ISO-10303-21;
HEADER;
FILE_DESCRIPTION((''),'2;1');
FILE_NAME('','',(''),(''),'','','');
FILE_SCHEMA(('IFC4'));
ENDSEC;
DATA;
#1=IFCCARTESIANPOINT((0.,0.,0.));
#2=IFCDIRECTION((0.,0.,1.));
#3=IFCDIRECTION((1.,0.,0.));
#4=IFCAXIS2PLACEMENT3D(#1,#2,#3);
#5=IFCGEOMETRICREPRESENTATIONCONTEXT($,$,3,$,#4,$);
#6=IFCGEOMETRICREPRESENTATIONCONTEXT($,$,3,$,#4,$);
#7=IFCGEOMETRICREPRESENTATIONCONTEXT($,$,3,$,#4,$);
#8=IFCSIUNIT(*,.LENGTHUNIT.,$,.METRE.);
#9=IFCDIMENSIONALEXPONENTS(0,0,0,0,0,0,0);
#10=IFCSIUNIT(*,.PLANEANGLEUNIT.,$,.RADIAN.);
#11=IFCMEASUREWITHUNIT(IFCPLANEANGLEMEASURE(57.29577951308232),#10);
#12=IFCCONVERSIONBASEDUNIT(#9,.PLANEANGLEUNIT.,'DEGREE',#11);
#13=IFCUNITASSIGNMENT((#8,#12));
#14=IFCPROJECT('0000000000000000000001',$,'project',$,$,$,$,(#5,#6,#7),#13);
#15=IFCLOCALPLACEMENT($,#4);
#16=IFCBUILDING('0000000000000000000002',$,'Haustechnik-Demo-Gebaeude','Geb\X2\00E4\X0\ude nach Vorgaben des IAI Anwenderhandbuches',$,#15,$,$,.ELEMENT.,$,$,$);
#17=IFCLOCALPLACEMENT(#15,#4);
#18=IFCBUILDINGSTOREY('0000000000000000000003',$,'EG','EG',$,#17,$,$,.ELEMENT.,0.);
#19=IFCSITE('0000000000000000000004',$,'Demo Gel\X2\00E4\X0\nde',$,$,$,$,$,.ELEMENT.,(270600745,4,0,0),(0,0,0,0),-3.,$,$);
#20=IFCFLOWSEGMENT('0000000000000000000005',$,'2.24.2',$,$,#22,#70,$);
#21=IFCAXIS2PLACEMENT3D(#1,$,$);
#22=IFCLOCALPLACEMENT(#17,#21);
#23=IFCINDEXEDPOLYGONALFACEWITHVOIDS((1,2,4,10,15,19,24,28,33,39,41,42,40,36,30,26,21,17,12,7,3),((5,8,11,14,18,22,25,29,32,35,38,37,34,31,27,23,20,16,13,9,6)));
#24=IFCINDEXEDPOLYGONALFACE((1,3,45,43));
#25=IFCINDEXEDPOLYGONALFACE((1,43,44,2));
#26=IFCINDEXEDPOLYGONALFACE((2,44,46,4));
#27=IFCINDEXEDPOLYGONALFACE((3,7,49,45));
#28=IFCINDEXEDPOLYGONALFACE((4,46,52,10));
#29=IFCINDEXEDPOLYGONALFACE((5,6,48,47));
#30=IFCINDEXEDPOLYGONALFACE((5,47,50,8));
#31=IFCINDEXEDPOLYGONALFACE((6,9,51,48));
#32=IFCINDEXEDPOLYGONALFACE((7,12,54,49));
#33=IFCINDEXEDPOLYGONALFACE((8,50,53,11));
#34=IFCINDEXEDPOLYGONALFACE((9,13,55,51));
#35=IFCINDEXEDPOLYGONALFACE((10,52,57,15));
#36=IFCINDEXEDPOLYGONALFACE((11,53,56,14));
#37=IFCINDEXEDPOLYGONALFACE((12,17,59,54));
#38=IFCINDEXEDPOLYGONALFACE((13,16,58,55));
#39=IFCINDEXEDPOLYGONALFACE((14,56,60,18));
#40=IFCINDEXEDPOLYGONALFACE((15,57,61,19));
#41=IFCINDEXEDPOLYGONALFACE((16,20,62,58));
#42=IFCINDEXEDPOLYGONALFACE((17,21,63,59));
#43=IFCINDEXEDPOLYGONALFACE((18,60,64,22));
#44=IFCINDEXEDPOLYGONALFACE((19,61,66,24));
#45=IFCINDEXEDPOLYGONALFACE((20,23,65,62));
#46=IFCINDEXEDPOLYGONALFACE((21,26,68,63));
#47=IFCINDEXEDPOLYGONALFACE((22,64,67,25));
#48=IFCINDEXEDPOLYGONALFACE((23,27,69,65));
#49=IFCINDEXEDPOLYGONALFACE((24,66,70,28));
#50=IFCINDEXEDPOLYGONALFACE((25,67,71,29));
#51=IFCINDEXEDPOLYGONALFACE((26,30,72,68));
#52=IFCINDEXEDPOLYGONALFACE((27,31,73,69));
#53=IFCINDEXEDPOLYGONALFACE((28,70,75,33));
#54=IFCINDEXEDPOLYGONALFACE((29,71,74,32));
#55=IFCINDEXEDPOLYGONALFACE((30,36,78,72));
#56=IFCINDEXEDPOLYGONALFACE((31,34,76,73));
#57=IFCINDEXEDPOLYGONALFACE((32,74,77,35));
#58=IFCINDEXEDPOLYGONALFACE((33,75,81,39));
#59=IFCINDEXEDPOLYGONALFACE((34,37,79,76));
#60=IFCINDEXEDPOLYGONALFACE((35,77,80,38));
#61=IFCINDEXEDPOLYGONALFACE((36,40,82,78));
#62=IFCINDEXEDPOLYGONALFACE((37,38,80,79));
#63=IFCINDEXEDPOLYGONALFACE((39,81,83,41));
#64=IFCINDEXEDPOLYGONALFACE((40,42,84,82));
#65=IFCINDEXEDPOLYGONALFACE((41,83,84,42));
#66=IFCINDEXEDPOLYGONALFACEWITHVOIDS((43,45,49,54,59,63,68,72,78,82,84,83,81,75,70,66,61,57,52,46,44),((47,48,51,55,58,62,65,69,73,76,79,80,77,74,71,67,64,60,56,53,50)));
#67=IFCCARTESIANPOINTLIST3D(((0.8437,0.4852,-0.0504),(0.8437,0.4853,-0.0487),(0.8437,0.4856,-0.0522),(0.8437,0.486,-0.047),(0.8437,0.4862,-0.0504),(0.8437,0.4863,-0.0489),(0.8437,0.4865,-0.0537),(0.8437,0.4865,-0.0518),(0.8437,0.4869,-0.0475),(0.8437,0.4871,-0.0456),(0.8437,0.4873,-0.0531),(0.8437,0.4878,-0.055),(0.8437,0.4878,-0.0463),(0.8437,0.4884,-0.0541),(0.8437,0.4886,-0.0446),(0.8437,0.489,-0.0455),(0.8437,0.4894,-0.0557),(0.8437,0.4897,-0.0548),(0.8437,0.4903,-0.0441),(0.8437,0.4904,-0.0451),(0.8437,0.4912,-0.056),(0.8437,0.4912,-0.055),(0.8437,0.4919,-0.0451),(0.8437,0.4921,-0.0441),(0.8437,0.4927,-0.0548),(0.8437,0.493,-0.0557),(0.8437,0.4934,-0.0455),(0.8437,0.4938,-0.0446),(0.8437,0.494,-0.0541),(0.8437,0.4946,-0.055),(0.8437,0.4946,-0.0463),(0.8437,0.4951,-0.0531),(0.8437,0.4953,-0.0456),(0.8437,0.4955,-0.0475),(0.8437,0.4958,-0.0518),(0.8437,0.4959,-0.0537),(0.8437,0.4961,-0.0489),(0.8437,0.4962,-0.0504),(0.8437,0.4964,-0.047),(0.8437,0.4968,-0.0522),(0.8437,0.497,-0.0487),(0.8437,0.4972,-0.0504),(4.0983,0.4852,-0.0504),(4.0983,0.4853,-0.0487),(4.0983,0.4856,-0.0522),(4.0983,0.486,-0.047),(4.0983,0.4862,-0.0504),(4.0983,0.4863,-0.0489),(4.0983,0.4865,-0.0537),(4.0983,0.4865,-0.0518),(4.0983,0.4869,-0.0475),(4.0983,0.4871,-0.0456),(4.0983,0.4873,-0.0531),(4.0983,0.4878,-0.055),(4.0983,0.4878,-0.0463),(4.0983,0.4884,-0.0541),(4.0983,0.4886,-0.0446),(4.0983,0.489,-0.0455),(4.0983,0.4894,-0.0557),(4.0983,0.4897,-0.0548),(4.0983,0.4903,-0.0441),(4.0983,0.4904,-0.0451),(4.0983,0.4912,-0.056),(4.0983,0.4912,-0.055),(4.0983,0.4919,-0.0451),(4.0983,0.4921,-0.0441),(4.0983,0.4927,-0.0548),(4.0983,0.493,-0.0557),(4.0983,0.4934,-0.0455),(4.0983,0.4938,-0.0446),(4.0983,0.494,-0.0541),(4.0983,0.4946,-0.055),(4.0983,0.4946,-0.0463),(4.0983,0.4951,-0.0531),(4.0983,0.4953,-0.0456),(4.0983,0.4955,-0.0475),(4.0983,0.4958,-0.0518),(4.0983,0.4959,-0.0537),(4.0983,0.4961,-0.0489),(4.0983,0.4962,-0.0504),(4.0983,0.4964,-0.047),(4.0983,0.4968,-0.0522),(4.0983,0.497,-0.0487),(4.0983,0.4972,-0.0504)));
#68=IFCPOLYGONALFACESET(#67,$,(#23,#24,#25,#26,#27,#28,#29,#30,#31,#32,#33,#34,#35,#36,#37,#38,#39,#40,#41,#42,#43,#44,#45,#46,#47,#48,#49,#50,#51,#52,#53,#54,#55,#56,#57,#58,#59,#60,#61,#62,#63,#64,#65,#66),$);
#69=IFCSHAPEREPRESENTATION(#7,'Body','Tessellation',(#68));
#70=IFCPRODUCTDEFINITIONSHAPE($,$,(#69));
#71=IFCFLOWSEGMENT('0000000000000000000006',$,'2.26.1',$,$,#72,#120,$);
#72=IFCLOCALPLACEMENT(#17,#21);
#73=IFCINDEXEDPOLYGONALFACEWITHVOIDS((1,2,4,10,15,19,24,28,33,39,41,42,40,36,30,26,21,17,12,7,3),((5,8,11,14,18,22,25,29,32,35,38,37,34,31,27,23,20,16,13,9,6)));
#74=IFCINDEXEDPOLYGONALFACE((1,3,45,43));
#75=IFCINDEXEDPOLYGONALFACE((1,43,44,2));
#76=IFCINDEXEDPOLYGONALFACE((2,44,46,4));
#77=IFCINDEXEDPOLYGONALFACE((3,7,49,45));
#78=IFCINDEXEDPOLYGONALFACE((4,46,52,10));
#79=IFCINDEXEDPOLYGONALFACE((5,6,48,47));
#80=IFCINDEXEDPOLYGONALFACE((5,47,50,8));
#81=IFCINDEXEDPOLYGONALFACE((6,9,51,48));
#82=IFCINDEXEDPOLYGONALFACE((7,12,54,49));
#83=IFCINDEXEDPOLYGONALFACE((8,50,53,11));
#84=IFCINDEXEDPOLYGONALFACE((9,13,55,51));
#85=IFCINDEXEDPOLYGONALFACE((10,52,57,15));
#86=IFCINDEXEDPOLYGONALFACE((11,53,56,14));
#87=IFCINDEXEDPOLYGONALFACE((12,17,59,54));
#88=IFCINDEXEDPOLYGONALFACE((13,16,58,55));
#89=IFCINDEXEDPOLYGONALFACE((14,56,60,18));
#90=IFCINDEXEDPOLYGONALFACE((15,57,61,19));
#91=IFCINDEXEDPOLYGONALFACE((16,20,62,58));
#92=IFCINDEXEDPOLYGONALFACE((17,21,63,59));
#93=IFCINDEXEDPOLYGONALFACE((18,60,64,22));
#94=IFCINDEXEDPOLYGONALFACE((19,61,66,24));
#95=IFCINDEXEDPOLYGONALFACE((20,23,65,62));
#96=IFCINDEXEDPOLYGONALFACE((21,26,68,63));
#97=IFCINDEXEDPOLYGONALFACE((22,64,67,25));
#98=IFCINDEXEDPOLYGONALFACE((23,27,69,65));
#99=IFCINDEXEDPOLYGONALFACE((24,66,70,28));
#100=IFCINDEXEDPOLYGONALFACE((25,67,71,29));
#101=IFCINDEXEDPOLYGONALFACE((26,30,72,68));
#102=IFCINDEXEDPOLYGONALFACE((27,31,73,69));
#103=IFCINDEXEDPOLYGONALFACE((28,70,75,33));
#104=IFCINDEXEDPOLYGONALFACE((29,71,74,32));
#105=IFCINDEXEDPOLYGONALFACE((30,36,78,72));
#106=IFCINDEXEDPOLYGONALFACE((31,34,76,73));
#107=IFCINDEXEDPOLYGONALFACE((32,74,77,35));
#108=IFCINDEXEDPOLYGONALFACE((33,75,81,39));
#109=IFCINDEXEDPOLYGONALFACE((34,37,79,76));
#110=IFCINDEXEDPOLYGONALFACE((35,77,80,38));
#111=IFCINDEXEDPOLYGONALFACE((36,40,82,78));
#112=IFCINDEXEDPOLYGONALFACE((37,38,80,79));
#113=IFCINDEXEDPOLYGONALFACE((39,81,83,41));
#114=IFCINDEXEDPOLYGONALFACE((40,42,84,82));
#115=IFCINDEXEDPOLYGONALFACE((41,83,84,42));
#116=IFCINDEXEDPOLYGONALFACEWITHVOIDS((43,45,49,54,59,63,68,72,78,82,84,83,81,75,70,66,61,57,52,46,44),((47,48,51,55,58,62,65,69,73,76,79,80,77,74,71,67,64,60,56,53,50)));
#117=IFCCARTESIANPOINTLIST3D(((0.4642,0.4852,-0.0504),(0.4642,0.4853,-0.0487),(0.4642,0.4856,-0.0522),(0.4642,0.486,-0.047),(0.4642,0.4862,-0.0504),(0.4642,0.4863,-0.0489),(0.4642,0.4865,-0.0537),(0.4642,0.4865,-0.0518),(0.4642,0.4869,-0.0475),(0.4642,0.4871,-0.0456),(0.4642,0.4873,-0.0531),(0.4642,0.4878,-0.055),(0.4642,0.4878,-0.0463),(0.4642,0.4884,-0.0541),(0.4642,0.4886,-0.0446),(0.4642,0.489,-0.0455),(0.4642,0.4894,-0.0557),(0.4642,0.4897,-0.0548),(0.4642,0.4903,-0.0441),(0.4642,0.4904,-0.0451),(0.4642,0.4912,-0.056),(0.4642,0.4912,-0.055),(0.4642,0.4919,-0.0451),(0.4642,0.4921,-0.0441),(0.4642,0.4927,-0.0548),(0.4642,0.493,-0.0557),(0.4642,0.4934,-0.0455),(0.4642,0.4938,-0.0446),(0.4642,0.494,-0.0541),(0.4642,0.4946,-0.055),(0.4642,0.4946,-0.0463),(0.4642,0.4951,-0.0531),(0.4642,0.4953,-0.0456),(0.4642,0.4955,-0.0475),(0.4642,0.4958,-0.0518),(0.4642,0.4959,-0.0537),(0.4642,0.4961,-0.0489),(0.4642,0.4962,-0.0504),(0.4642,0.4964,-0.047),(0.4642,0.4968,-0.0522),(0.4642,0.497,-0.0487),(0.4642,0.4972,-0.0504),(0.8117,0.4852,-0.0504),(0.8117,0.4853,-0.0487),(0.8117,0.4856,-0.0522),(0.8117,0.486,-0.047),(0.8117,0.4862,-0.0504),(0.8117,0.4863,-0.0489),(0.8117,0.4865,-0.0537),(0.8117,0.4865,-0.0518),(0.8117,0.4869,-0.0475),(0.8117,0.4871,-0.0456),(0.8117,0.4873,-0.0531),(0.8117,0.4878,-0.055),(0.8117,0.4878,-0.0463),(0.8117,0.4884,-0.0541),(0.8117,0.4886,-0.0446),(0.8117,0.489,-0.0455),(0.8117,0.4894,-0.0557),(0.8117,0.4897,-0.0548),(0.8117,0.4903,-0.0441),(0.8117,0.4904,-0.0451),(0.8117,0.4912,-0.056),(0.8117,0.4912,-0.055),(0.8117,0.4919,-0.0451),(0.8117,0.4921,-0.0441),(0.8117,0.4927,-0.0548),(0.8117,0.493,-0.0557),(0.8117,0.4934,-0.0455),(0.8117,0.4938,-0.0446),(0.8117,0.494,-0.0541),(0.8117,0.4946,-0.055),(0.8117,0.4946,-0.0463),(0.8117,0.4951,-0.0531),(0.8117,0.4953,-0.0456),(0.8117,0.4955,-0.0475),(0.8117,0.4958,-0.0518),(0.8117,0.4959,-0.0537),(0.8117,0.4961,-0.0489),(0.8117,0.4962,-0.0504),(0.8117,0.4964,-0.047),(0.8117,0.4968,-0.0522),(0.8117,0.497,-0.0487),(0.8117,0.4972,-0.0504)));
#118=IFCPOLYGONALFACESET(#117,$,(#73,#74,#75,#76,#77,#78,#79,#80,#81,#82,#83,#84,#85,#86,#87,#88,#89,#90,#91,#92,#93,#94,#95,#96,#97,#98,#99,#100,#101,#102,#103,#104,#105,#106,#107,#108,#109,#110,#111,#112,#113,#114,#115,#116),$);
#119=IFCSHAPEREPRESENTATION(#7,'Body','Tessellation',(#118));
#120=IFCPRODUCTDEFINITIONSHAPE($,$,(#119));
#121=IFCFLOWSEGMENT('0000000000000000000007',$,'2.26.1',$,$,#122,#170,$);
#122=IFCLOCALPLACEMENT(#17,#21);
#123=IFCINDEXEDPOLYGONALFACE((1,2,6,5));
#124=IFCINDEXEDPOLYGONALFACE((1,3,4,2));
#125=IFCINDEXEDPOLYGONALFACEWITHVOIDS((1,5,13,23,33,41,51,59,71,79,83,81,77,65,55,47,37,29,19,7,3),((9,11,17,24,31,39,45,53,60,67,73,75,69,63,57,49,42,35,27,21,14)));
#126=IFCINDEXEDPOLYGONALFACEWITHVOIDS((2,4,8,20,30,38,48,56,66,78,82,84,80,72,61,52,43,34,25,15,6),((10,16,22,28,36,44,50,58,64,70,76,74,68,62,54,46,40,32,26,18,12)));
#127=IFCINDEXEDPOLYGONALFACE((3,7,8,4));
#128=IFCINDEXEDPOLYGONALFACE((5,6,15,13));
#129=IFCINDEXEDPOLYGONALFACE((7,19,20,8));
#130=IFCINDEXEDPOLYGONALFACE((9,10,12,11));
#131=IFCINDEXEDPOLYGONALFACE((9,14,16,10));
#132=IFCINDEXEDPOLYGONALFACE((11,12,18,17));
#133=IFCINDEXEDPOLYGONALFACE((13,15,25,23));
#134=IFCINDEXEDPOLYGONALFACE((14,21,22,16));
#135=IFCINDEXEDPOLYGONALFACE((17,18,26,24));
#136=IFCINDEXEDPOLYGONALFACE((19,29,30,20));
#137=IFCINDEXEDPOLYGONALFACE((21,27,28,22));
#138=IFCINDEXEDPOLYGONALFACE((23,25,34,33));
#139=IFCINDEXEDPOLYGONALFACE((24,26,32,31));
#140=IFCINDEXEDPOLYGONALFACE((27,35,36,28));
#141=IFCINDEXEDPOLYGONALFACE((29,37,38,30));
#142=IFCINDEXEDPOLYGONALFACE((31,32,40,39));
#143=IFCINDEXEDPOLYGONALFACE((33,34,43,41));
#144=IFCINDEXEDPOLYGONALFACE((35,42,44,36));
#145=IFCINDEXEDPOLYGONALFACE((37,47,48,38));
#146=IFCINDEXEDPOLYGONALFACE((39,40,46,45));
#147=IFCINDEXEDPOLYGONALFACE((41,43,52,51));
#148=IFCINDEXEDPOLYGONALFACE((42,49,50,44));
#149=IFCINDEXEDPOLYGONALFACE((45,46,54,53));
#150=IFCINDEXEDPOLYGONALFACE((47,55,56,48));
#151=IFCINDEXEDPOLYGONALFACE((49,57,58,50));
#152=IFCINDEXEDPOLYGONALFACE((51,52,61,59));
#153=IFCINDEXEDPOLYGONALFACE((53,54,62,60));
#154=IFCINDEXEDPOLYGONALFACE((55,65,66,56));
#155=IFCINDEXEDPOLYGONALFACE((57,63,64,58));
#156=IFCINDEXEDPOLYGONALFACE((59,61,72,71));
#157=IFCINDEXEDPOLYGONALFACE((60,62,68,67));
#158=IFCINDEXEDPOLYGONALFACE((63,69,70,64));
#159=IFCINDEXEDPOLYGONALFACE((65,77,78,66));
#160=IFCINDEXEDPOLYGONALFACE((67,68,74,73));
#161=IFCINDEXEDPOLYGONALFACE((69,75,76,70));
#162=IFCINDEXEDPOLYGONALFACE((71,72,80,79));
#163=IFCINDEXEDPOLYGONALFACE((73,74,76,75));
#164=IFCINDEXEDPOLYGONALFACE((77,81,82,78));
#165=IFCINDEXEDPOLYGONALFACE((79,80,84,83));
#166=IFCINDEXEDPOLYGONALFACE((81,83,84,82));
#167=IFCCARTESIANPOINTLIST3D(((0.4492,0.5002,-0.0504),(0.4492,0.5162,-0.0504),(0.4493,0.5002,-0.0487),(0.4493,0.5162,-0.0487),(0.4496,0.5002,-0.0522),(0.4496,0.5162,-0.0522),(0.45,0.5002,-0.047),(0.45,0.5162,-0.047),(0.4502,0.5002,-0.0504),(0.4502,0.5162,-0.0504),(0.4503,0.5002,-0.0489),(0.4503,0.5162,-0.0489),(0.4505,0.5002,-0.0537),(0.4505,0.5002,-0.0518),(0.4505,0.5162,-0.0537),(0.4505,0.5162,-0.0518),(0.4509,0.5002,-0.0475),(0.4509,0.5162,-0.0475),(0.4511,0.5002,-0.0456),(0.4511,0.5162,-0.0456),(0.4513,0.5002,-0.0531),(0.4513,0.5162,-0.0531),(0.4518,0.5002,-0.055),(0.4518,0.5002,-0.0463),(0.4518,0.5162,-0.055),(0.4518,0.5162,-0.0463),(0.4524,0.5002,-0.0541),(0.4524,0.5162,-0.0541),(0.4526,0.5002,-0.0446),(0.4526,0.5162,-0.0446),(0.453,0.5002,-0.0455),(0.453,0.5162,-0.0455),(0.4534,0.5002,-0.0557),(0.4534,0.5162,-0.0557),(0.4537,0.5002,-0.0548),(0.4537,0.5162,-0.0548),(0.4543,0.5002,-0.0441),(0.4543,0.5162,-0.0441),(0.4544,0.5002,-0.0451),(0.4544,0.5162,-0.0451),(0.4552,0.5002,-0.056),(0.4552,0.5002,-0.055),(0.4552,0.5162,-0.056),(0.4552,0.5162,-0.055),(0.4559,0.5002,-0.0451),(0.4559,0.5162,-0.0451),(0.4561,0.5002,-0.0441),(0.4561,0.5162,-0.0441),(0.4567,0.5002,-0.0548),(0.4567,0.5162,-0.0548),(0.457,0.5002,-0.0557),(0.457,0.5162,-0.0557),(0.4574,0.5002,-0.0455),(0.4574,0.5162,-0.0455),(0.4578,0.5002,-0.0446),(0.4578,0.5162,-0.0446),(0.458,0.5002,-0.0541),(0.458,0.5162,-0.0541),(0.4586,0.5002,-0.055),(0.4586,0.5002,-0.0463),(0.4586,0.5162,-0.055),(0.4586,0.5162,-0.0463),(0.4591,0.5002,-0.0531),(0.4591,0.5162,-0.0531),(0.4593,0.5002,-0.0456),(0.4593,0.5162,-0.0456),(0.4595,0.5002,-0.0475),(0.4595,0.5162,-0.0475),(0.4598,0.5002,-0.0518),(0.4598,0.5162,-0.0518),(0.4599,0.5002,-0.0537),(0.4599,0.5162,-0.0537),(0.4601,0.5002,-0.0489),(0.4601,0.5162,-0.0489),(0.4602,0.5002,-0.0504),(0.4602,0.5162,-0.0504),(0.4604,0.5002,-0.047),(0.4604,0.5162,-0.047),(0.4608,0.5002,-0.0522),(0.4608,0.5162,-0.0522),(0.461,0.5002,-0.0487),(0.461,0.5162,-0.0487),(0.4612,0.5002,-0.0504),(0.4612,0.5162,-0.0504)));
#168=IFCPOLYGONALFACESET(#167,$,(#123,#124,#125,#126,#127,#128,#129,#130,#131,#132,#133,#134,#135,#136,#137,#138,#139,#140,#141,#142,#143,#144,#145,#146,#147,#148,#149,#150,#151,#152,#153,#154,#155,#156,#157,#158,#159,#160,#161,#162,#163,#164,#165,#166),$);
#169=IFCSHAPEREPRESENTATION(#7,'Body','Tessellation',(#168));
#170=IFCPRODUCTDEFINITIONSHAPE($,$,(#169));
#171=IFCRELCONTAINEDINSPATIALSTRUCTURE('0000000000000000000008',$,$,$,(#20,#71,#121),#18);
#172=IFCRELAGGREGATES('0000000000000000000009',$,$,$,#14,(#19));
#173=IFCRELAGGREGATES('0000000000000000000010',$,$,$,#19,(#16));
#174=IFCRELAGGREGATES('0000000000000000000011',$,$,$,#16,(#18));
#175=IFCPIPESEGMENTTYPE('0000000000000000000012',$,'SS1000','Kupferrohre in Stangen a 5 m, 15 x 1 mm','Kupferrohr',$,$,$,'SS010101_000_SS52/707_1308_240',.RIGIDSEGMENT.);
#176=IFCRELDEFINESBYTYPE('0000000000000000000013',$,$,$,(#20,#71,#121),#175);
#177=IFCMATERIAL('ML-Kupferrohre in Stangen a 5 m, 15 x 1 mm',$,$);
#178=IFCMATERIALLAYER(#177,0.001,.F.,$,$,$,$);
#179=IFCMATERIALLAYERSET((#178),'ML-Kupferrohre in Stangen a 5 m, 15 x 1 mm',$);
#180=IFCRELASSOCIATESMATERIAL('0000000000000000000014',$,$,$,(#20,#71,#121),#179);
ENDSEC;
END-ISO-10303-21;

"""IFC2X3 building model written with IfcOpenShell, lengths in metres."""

from ifc_helpers import new_model, entity, si_unit, converted_unit, frame, origin_with_axes, origin_2d_with_axis, place, context, project, spatial, hollow_circle, extrude, material, layer, layer_set, layer_usage, type_object, element, save


model = new_model("IFC2X3")

# Units and contexts
context_of_model_1 = context(None, 3, world=origin_with_axes())
context_of_model_2 = context(None, 3, world=origin_with_axes())
context_of_model_3 = context(None, 3, world=origin_with_axes())
ifc_project = project(units=[si_unit("LENGTHUNIT", "METRE"), converted_unit("PLANEANGLEUNIT", "DEGREE", entity("IfcPlaneAngleMeasure", 57.29577951308232), si_unit("PLANEANGLEUNIT", "RADIAN"), dimensions=[0, 0, 0, 0, 0, 0, 0])], contexts=[context_of_model_1, context_of_model_2, context_of_model_3])

# Site, building, storey
site = spatial("IfcSite", under=ifc_project, Name="Demo Gelände", CompositionType="ELEMENT", RefLatitude=(270600745, 4, 0, 0), RefLongitude=(0, 0, 0, 0), RefElevation=-3.0)
building_placement = place(None, origin_with_axes())
building = spatial("IfcBuilding", under=site, at=building_placement, Name="Haustechnik-Demo-Gebaeude", Description="Gebäude nach Vorgaben des IAI Anwenderhandbuches", CompositionType="ELEMENT")
storey_placement = place(building_placement, origin_with_axes())
storey = spatial("IfcBuildingStorey", under=building, at=storey_placement, Name="EG", Description="EG", CompositionType="ELEMENT", Elevation=0.0)

# Flow segments
ifc_material = material(Name="ML-Kupferrohre in Stangen a 5 m, 15 x 1 mm")
ifc_layer = layer(ifc_material, 0.001, ventilated=False)
ifc_layer_set = layer_set([ifc_layer], Name="ML-Kupferrohre in Stangen a 5 m, 15 x 1 mm")
ifc_layer_usage = layer_usage(ifc_layer_set, "AXIS2", "POSITIVE", 0.0)
pipe_segment_type_1 = type_object("IfcPipeSegmentType", Name="SS1000", Description="Kupferrohre in Stangen a 5 m, 15 x 1 mm", ApplicableOccurrence="Kupferrohr", ElementType="SS010101_000_SS52/707_1308_240", PredefinedType="RIGIDSEGMENT")
flow_segment_1_placement = place(storey_placement, frame((4.0983, 0.4912, -0.05), z_axis=(-1.0, 0.0, 0.0), x_axis=(0.0, 0.0, -1.0)))
element("IfcFlowSegment", 1, at=flow_segment_1_placement, inside=storey, type_object=pipe_segment_type_1, material=ifc_layer_usage, Name="2.24.2", context=context_of_model_3, shape_type="SweptSolid", body=[
    extrude(hollow_circle(Radius=0.006, WallThickness=0.001, at=origin_2d_with_axis()), origin_with_axes(), (0.0, 0.0, 1.0), 3.2546),
])
flow_segment_2_placement = place(storey_placement, frame((0.8117, 0.4912, -0.05), z_axis=(-1.0, 0.0, 0.0), x_axis=(0.0, 0.0, -1.0)))
element("IfcFlowSegment", 2, at=flow_segment_2_placement, inside=storey, type_object=pipe_segment_type_1, material=ifc_layer_usage, Name="2.26.1", context=context_of_model_3, shape_type="SweptSolid", body=[
    extrude(hollow_circle(Radius=0.006, WallThickness=0.001, at=origin_2d_with_axis()), origin_with_axes(), (0.0, 0.0, 1.0), 0.3475),
])
flow_segment_3_placement = place(storey_placement, frame((0.4552, 0.5002, -0.05), z_axis=(0.0, 1.0, 0.0), x_axis=(0.0, 0.0, -1.0)))
element("IfcFlowSegment", 3, at=flow_segment_3_placement, inside=storey, type_object=pipe_segment_type_1, material=ifc_layer_usage, Name="2.26.1", context=context_of_model_3, shape_type="SweptSolid", body=[
    extrude(hollow_circle(Radius=0.006, WallThickness=0.001, at=origin_2d_with_axis()), origin_with_axes(), (0.0, 0.0, 1.0), 0.016),
])

save(model, "model.ifc")
